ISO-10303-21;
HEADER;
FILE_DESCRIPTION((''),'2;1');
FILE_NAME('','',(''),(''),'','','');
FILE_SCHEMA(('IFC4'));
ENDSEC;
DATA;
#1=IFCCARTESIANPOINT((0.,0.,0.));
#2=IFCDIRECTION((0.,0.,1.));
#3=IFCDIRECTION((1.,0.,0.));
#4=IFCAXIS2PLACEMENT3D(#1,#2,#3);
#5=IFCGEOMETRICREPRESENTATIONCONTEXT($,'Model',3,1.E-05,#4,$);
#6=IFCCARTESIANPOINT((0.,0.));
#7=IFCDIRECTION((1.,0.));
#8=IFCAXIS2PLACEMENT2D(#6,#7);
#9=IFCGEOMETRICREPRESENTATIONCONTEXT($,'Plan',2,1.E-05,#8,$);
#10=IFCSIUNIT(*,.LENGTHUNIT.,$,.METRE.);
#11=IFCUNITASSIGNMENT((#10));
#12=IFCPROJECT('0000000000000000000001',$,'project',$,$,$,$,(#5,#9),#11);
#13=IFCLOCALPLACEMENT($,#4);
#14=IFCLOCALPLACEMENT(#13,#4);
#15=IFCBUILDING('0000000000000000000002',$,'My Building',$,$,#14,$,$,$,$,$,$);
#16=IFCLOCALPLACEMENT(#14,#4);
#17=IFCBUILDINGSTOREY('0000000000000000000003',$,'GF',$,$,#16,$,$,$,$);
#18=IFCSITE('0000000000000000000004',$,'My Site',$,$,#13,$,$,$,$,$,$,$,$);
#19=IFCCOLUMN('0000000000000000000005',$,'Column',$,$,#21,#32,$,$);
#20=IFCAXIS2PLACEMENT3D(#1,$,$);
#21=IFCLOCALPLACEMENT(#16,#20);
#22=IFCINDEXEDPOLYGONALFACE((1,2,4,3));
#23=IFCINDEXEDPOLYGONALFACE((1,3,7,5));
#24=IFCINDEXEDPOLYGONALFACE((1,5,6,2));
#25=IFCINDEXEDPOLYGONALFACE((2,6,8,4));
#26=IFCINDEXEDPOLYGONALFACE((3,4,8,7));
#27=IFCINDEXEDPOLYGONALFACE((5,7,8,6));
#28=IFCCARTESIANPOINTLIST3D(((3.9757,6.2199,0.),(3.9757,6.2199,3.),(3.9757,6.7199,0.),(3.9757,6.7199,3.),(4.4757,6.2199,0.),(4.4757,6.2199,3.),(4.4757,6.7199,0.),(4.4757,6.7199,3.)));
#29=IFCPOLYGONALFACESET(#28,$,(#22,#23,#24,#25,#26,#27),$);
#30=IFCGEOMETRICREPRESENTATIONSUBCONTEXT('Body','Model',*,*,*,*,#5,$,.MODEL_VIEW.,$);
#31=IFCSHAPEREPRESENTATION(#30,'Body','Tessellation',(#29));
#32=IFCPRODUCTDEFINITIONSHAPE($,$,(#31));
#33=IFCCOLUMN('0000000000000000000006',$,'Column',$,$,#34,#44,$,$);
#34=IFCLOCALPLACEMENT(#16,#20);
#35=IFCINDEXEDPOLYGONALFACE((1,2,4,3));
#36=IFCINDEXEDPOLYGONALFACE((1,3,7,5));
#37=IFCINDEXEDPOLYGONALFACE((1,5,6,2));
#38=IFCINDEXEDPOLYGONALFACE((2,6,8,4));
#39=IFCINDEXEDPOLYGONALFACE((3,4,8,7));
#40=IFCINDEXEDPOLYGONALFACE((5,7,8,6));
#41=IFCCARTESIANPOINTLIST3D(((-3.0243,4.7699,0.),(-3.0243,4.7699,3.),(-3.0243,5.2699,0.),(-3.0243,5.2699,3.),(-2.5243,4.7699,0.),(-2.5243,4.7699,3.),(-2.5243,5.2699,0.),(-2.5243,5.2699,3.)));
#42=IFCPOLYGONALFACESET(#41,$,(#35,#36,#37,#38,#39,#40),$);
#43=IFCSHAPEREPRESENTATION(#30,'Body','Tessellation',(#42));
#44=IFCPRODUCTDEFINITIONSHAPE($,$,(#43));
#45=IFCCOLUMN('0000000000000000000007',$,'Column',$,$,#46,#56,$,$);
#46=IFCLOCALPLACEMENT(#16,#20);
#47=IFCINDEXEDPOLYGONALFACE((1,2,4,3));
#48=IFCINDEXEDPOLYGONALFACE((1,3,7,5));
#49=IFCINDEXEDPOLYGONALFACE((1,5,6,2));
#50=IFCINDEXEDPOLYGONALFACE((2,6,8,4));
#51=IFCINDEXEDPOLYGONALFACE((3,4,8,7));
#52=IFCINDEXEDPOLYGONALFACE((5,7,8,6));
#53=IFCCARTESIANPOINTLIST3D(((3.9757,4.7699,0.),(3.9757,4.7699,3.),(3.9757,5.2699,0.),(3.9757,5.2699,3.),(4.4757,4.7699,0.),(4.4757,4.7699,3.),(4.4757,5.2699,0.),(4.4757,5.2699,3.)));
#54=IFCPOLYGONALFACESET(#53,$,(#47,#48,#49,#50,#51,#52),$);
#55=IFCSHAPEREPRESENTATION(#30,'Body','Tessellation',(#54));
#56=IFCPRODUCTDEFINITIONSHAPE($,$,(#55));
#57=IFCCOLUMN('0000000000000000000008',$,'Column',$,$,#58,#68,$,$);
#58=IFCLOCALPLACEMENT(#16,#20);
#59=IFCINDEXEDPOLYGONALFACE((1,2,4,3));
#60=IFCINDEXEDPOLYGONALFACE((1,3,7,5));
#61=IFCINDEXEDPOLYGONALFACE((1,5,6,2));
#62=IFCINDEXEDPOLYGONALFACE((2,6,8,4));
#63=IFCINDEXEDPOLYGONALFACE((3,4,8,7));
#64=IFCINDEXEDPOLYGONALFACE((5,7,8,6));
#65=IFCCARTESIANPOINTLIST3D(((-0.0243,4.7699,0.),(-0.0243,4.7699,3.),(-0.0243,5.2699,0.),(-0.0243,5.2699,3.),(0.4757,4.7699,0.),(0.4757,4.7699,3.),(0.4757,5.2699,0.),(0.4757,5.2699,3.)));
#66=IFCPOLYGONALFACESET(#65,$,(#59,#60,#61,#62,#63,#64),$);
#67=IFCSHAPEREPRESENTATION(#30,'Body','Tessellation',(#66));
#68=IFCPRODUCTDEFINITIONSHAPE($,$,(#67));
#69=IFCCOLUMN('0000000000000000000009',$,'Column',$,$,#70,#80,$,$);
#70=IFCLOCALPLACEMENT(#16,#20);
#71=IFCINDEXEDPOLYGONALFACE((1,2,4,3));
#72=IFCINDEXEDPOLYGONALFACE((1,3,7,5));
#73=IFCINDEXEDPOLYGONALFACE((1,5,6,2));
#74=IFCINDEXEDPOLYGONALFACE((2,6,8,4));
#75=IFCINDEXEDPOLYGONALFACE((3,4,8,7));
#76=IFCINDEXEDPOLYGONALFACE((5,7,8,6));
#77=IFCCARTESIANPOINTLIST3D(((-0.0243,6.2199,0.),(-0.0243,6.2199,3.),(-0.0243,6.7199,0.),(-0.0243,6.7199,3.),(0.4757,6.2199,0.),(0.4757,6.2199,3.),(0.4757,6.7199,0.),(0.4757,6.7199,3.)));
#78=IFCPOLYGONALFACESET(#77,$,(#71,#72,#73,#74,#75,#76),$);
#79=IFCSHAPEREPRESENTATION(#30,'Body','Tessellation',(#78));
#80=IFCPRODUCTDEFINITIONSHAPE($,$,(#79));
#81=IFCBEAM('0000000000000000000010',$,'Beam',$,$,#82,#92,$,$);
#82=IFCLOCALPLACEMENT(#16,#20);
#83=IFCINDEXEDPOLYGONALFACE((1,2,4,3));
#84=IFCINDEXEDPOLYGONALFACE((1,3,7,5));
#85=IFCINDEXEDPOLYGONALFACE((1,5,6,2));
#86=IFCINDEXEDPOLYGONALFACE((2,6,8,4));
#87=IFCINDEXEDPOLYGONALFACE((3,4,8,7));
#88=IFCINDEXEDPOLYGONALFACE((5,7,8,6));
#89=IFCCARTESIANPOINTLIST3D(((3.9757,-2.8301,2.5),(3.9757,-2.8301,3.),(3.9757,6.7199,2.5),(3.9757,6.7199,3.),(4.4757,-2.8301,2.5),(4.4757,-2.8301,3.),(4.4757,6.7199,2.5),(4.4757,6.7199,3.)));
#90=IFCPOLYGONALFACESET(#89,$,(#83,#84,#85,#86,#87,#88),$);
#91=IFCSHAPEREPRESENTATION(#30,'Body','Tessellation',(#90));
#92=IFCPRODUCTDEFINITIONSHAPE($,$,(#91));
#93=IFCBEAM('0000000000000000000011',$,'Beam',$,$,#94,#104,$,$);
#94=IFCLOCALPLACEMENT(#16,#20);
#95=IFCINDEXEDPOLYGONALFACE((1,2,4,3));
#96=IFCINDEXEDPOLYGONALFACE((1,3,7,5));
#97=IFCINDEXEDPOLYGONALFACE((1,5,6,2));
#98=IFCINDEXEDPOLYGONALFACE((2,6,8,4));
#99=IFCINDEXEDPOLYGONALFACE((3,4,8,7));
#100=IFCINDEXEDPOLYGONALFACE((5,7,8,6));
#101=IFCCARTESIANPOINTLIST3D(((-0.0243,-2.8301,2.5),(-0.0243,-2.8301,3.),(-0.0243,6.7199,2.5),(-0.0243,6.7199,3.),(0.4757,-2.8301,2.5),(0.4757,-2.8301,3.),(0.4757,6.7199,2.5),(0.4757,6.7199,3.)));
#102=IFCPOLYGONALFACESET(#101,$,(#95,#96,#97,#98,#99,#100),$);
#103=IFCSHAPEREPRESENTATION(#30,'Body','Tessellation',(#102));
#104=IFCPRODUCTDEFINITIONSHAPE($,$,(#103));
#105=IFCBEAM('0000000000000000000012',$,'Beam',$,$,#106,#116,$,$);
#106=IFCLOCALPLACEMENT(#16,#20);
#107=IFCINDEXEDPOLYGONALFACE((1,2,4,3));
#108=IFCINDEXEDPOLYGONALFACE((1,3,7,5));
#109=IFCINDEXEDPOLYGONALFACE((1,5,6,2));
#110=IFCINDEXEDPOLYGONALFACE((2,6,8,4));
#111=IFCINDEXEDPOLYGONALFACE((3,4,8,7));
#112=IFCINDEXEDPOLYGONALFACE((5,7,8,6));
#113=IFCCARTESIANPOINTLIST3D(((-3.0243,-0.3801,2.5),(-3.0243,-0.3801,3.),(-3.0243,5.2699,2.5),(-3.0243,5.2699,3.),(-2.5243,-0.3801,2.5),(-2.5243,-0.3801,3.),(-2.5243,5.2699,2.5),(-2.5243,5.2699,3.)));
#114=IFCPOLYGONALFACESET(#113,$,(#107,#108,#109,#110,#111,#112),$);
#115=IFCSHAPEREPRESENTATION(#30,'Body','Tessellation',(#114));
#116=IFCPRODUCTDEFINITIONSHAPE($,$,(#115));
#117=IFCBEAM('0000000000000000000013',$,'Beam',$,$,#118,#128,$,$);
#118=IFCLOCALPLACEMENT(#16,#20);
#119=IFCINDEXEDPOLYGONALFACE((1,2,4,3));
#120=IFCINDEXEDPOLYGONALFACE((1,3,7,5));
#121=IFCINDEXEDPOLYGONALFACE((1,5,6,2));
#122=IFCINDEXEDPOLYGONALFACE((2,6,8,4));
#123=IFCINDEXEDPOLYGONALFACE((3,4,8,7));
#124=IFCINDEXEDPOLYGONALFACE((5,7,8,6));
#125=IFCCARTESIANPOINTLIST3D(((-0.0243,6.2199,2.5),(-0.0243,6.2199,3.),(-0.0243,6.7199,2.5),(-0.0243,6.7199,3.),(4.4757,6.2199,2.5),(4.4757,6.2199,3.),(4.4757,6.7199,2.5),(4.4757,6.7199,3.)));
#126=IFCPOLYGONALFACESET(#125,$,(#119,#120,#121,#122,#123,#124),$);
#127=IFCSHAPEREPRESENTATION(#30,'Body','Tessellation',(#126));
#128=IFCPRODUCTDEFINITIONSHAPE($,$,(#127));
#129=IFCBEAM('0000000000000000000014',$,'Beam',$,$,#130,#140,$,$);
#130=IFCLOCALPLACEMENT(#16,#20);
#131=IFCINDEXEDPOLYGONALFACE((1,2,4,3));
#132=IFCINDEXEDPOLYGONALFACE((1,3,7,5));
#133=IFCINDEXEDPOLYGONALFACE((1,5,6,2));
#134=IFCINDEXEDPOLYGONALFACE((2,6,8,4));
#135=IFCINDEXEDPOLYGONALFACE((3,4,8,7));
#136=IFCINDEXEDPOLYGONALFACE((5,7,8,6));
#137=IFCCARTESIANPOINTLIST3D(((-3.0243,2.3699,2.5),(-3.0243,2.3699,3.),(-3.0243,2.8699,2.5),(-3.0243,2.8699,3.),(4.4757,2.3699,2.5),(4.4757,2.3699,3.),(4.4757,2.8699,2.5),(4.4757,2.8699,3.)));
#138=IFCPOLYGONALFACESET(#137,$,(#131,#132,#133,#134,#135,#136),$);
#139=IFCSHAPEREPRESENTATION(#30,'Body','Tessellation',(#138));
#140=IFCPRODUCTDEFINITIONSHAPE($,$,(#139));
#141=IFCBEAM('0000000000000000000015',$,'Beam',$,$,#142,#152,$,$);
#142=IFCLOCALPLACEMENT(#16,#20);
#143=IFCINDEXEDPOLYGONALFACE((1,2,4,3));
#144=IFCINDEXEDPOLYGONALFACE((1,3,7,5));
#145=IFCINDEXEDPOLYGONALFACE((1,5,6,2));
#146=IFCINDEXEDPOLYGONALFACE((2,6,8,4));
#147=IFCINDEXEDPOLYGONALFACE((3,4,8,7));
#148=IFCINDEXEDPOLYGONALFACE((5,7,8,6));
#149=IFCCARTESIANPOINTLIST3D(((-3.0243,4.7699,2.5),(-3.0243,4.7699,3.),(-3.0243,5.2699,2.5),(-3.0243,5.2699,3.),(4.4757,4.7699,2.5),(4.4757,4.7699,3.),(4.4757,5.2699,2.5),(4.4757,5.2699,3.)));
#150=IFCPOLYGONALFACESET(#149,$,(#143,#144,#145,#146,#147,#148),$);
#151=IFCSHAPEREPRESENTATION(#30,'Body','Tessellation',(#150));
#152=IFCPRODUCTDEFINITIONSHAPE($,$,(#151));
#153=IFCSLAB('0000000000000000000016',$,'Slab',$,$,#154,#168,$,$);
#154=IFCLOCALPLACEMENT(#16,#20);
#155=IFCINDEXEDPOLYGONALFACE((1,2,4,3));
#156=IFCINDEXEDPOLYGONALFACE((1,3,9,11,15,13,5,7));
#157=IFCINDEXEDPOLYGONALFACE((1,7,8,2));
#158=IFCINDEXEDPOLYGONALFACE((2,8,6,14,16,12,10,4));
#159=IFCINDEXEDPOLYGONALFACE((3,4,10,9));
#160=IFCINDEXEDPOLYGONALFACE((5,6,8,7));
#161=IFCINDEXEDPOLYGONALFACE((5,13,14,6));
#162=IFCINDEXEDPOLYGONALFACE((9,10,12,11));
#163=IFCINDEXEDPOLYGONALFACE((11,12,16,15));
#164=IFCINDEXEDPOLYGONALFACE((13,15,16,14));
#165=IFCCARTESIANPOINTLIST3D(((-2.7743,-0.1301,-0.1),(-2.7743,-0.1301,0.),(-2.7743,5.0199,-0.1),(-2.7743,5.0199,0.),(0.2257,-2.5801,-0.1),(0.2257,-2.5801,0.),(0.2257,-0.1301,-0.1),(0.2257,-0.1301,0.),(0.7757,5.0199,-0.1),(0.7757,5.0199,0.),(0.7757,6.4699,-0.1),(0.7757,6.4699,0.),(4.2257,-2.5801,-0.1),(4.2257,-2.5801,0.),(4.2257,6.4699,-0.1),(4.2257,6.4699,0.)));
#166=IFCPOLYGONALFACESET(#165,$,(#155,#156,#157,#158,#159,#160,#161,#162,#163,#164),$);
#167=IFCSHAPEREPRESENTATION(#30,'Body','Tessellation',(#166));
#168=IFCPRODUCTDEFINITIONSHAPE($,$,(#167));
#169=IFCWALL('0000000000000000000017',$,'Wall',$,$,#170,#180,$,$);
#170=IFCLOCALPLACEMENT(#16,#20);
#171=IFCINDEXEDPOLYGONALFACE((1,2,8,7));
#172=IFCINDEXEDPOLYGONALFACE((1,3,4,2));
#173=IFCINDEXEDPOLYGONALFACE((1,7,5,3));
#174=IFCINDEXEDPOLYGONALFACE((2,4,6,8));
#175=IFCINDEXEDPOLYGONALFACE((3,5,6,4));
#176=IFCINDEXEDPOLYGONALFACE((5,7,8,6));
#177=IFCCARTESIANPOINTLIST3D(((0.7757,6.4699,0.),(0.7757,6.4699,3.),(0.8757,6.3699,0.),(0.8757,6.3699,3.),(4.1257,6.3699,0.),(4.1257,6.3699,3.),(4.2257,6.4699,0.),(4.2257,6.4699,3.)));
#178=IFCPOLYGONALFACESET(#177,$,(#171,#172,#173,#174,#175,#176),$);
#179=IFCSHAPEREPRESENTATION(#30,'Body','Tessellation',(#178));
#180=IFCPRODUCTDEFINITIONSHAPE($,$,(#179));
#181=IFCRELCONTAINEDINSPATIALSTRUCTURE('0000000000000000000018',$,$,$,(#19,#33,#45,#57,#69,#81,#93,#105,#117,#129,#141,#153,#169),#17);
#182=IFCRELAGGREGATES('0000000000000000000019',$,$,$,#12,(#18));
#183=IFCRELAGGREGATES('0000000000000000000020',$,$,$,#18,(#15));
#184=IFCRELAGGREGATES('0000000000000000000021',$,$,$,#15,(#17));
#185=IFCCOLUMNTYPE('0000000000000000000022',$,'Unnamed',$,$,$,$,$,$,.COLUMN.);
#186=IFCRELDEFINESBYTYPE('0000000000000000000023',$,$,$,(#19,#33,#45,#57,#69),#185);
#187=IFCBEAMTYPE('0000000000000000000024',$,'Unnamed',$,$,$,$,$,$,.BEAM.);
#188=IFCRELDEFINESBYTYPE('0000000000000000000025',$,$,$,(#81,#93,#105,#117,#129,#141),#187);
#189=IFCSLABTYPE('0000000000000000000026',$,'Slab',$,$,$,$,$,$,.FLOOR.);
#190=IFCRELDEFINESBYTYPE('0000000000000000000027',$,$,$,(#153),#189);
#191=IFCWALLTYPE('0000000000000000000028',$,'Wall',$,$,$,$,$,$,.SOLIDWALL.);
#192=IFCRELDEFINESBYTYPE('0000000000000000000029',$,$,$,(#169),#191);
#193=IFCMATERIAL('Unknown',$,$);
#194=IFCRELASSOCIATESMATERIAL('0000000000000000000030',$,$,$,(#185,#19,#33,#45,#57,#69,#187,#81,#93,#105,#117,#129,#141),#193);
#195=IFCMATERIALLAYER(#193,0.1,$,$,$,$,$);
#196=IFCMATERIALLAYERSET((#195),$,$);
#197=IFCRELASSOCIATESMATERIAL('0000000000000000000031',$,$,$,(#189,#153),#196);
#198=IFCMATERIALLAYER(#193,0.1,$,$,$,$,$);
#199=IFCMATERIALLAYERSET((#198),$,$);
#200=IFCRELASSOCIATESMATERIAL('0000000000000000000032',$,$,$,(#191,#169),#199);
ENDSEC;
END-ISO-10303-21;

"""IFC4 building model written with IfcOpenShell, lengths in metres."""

from ifc_helpers import new_model, si_unit, frame, origin_with_axes, origin_2d_with_axis, place, context, subcontext, project, spatial, line, indexed_curve, rectangle, outline, extrude, material, layer, layer_set, layer_usage, material_profile, profile_set, profile_usage, type_object, element, save


model = new_model("IFC4")

# Units and contexts
model_context = context("Model", 3, precision=1e-05, world=origin_with_axes())
plan_context = context("Plan", 2, precision=1e-05, world=origin_2d_with_axis())
body_context_1 = subcontext(model_context, "Body", "Model", "MODEL_VIEW")
ifc_project = project(units=[si_unit("LENGTHUNIT", "METRE")], contexts=[model_context, plan_context])

# Site, building, storey
site_placement = place(None, origin_with_axes())
site = spatial("IfcSite", under=ifc_project, at=site_placement, Name="My Site")
building_placement = place(site_placement, origin_with_axes())
building = spatial("IfcBuilding", under=site, at=building_placement, Name="My Building")
storey_placement = place(building_placement, origin_with_axes())
storey = spatial("IfcBuildingStorey", under=building, at=storey_placement, Name="GF")

# Columns
ifc_material_1 = material(Name="Unknown")
ifc_material_profile_1 = material_profile(ifc_material_1, rectangle(XDim=0.5, YDim=0.5))
ifc_profile_set_1 = profile_set([ifc_material_profile_1])
ifc_profile_usage_1 = profile_usage(ifc_profile_set_1, cardinal=5)
column_type = type_object("IfcColumnType", Name="Unnamed", PredefinedType="COLUMN", material=ifc_profile_set_1)
column_1_placement = place(storey_placement, frame((4.2257, 6.4699, 0.0), z_axis=(0.0, 0.0, 1.0), x_axis=(1.0, 0.0, 0.0)))
element("IfcColumn", 1, at=column_1_placement, inside=storey, type_object=column_type, material=ifc_profile_usage_1, Name="Column", context=body_context_1, shape_type="SweptSolid", body=[
    extrude(rectangle(XDim=0.5, YDim=0.5), origin_with_axes(), (0.0, 0.0, 1.0), 3.0),
])
ifc_profile_usage_2 = profile_usage(ifc_profile_set_1, cardinal=5)
column_2_placement = place(storey_placement, frame((-2.7743, 5.0199, 0.0), z_axis=(0.0, 0.0, 1.0), x_axis=(1.0, 0.0, 0.0)))
element("IfcColumn", 2, at=column_2_placement, inside=storey, type_object=column_type, material=ifc_profile_usage_2, Name="Column", context=body_context_1, shape_type="SweptSolid", body=[
    extrude(rectangle(XDim=0.5, YDim=0.5), origin_with_axes(), (0.0, 0.0, 1.0), 3.0),
])
ifc_profile_usage_3 = profile_usage(ifc_profile_set_1, cardinal=5)
column_3_placement = place(storey_placement, frame((4.2257, 5.0199, 0.0), z_axis=(0.0, 0.0, 1.0), x_axis=(1.0, 0.0, 0.0)))
element("IfcColumn", 3, at=column_3_placement, inside=storey, type_object=column_type, material=ifc_profile_usage_3, Name="Column", context=body_context_1, shape_type="SweptSolid", body=[
    extrude(rectangle(XDim=0.5, YDim=0.5), origin_with_axes(), (0.0, 0.0, 1.0), 3.0),
])
ifc_profile_usage_4 = profile_usage(ifc_profile_set_1, cardinal=5)
column_4_placement = place(storey_placement, frame((0.2257, 5.0199, 0.0), z_axis=(0.0, 0.0, 1.0), x_axis=(1.0, 0.0, 0.0)))
element("IfcColumn", 4, at=column_4_placement, inside=storey, type_object=column_type, material=ifc_profile_usage_4, Name="Column", context=body_context_1, shape_type="SweptSolid", body=[
    extrude(rectangle(XDim=0.5, YDim=0.5), origin_with_axes(), (0.0, 0.0, 1.0), 3.0),
])
ifc_profile_usage_5 = profile_usage(ifc_profile_set_1, cardinal=5)
column_5_placement = place(storey_placement, frame((0.2257, 6.4699, 0.0), z_axis=(0.0, 0.0, 1.0), x_axis=(1.0, 0.0, 0.0)))
element("IfcColumn", 5, at=column_5_placement, inside=storey, type_object=column_type, material=ifc_profile_usage_5, Name="Column", context=body_context_1, shape_type="SweptSolid", body=[
    extrude(rectangle(XDim=0.5, YDim=0.5), origin_with_axes(), (0.0, 0.0, 1.0), 3.0),
])

# Beams
ifc_material_profile_2 = material_profile(ifc_material_1, rectangle(XDim=0.5, YDim=0.5))
ifc_profile_set_2 = profile_set([ifc_material_profile_2])
ifc_profile_usage_6 = profile_usage(ifc_profile_set_2, cardinal=7)
beam_type = type_object("IfcBeamType", Name="Unnamed", PredefinedType="BEAM", material=ifc_profile_set_2)
beam_1_placement = place(storey_placement, frame((4.4757, 6.7199, 3.0), z_axis=(0.0, -1.0, 0.0), x_axis=(1.0, 0.0, 0.0)))
element("IfcBeam", 6, at=beam_1_placement, inside=storey, type_object=beam_type, material=ifc_profile_usage_6, Name="Beam", context=body_context_1, shape_type="SweptSolid", body=[
    extrude(rectangle(XDim=0.5, YDim=0.5), frame((-0.25, -0.25, 0.0), z_axis=(0.0, 0.0, 1.0), x_axis=(1.0, 0.0, 0.0)), (0.0, 0.0, 1.0), 9.55),
])
ifc_profile_usage_7 = profile_usage(ifc_profile_set_2, cardinal=7)
beam_2_placement = place(storey_placement, frame((0.4757, 6.7199, 3.0), z_axis=(0.0, -1.0, 0.0), x_axis=(1.0, 0.0, 0.0)))
element("IfcBeam", 7, at=beam_2_placement, inside=storey, type_object=beam_type, material=ifc_profile_usage_7, Name="Beam", context=body_context_1, shape_type="SweptSolid", body=[
    extrude(rectangle(XDim=0.5, YDim=0.5), frame((-0.25, -0.25, 0.0), z_axis=(0.0, 0.0, 1.0), x_axis=(1.0, 0.0, 0.0)), (0.0, 0.0, 1.0), 9.55),
])
ifc_profile_usage_8 = profile_usage(ifc_profile_set_2, cardinal=7)
beam_3_placement = place(storey_placement, frame((-2.5243, 5.2699, 3.0), z_axis=(0.0, -1.0, 0.0), x_axis=(1.0, 0.0, 0.0)))
element("IfcBeam", 8, at=beam_3_placement, inside=storey, type_object=beam_type, material=ifc_profile_usage_8, Name="Beam", context=body_context_1, shape_type="SweptSolid", body=[
    extrude(rectangle(XDim=0.5, YDim=0.5), frame((-0.25, -0.25, 0.0), z_axis=(0.0, 0.0, 1.0), x_axis=(1.0, 0.0, 0.0)), (0.0, 0.0, 1.0), 5.65),
])
ifc_profile_usage_9 = profile_usage(ifc_profile_set_2, cardinal=7)
beam_4_placement = place(storey_placement, frame((-0.0243, 6.7199, 3.0), z_axis=(1.0, 0.0, 0.0), x_axis=(0.0, 1.0, 0.0)))
element("IfcBeam", 9, at=beam_4_placement, inside=storey, type_object=beam_type, material=ifc_profile_usage_9, Name="Beam", context=body_context_1, shape_type="SweptSolid", body=[
    extrude(rectangle(XDim=0.5, YDim=0.5), frame((-0.25, -0.25, 0.0), z_axis=(0.0, 0.0, 1.0), x_axis=(1.0, 0.0, 0.0)), (0.0, 0.0, 1.0), 4.5),
])
ifc_profile_usage_10 = profile_usage(ifc_profile_set_2, cardinal=7)
beam_5_placement = place(storey_placement, frame((-3.0243, 2.8699, 3.0), z_axis=(1.0, -0.000001, 0.000001), x_axis=(0.000001, 1.0, 0.0)))
element("IfcBeam", 10, at=beam_5_placement, inside=storey, type_object=beam_type, material=ifc_profile_usage_10, Name="Beam", context=body_context_1, shape_type="SweptSolid", body=[
    extrude(rectangle(XDim=0.5, YDim=0.5), frame((-0.25, -0.25, 0.0), z_axis=(0.0, 0.0, 1.0), x_axis=(1.0, 0.0, 0.0)), (0.0, 0.0, 1.0), 7.5),
])
ifc_profile_usage_11 = profile_usage(ifc_profile_set_2, cardinal=7)
beam_6_placement = place(storey_placement, frame((-3.0243, 5.2699, 3.0), z_axis=(1.0, -0.000001, 0.000001), x_axis=(0.000001, 1.0, 0.0)))
element("IfcBeam", 11, at=beam_6_placement, inside=storey, type_object=beam_type, material=ifc_profile_usage_11, Name="Beam", context=body_context_1, shape_type="SweptSolid", body=[
    extrude(rectangle(XDim=0.5, YDim=0.5), frame((-0.25, -0.25, 0.0), z_axis=(0.0, 0.0, 1.0), x_axis=(1.0, 0.0, 0.0)), (0.0, 0.0, 1.0), 7.5),
])

# Slab
ifc_layer_1 = layer(ifc_material_1, 0.1)
ifc_layer_set_1 = layer_set([ifc_layer_1])
ifc_layer_usage_1 = layer_usage(ifc_layer_set_1, "AXIS3", "POSITIVE", -0.1)
slab_type = type_object("IfcSlabType", Name="Slab", PredefinedType="FLOOR", material=ifc_layer_set_1)
slab_placement = place(storey_placement, frame((4.2257, 6.4699, 0.0), z_axis=(0.0, 0.0, 1.0), x_axis=(1.0, 0.0, 0.0)))
element("IfcSlab", 12, at=slab_placement, inside=storey, type_object=slab_type, material=ifc_layer_usage_1, Name="Slab", context=body_context_1, shape_type="SweptSolid", body=[
    extrude(outline(indexed_curve([(0.0, 0.0), (-3.45, 0.0), (-3.45, -1.45), (-7.0, -1.45), (-7.0, -6.6), (-4.0, -6.6), (-4.0, -9.05), (0.0, -9.05), (0.0, 0.0)])), frame((0.0, 0.0, -0.1), z_axis=(0.0, 0.0, 1.0), x_axis=(1.0, 0.0, 0.0)), (0.0, 0.0, 1.0), 0.1),
])

# Wall
ifc_layer_2 = layer(ifc_material_1, 0.1)
ifc_layer_set_2 = layer_set([ifc_layer_2])
ifc_layer_usage_2 = layer_usage(ifc_layer_set_2, "AXIS2", "POSITIVE", 0.0)
wall_type = type_object("IfcWallType", Name="Wall", PredefinedType="SOLIDWALL", material=ifc_layer_set_2)
wall_1_placement = place(storey_placement, frame((4.2257, 6.4699, 0.0), z_axis=(0.0, 0.0, 1.0), x_axis=(-1.0, 0.0, 0.0)))
element("IfcWall", 13, at=wall_1_placement, inside=storey, type_object=wall_type, material=ifc_layer_usage_2, Name="Wall", context=body_context_1, shape_type="SweptSolid", body=[
    extrude(outline(indexed_curve([(0.0, 0.0), (0.1, 0.1), (3.35, 0.1), (3.45, 0.0)], segments=[line(1, 2, 3, 4, 1)])), origin_with_axes(), (0.0, 0.0, 1.0), 3.0),
])

save(model, "model.ifc")
